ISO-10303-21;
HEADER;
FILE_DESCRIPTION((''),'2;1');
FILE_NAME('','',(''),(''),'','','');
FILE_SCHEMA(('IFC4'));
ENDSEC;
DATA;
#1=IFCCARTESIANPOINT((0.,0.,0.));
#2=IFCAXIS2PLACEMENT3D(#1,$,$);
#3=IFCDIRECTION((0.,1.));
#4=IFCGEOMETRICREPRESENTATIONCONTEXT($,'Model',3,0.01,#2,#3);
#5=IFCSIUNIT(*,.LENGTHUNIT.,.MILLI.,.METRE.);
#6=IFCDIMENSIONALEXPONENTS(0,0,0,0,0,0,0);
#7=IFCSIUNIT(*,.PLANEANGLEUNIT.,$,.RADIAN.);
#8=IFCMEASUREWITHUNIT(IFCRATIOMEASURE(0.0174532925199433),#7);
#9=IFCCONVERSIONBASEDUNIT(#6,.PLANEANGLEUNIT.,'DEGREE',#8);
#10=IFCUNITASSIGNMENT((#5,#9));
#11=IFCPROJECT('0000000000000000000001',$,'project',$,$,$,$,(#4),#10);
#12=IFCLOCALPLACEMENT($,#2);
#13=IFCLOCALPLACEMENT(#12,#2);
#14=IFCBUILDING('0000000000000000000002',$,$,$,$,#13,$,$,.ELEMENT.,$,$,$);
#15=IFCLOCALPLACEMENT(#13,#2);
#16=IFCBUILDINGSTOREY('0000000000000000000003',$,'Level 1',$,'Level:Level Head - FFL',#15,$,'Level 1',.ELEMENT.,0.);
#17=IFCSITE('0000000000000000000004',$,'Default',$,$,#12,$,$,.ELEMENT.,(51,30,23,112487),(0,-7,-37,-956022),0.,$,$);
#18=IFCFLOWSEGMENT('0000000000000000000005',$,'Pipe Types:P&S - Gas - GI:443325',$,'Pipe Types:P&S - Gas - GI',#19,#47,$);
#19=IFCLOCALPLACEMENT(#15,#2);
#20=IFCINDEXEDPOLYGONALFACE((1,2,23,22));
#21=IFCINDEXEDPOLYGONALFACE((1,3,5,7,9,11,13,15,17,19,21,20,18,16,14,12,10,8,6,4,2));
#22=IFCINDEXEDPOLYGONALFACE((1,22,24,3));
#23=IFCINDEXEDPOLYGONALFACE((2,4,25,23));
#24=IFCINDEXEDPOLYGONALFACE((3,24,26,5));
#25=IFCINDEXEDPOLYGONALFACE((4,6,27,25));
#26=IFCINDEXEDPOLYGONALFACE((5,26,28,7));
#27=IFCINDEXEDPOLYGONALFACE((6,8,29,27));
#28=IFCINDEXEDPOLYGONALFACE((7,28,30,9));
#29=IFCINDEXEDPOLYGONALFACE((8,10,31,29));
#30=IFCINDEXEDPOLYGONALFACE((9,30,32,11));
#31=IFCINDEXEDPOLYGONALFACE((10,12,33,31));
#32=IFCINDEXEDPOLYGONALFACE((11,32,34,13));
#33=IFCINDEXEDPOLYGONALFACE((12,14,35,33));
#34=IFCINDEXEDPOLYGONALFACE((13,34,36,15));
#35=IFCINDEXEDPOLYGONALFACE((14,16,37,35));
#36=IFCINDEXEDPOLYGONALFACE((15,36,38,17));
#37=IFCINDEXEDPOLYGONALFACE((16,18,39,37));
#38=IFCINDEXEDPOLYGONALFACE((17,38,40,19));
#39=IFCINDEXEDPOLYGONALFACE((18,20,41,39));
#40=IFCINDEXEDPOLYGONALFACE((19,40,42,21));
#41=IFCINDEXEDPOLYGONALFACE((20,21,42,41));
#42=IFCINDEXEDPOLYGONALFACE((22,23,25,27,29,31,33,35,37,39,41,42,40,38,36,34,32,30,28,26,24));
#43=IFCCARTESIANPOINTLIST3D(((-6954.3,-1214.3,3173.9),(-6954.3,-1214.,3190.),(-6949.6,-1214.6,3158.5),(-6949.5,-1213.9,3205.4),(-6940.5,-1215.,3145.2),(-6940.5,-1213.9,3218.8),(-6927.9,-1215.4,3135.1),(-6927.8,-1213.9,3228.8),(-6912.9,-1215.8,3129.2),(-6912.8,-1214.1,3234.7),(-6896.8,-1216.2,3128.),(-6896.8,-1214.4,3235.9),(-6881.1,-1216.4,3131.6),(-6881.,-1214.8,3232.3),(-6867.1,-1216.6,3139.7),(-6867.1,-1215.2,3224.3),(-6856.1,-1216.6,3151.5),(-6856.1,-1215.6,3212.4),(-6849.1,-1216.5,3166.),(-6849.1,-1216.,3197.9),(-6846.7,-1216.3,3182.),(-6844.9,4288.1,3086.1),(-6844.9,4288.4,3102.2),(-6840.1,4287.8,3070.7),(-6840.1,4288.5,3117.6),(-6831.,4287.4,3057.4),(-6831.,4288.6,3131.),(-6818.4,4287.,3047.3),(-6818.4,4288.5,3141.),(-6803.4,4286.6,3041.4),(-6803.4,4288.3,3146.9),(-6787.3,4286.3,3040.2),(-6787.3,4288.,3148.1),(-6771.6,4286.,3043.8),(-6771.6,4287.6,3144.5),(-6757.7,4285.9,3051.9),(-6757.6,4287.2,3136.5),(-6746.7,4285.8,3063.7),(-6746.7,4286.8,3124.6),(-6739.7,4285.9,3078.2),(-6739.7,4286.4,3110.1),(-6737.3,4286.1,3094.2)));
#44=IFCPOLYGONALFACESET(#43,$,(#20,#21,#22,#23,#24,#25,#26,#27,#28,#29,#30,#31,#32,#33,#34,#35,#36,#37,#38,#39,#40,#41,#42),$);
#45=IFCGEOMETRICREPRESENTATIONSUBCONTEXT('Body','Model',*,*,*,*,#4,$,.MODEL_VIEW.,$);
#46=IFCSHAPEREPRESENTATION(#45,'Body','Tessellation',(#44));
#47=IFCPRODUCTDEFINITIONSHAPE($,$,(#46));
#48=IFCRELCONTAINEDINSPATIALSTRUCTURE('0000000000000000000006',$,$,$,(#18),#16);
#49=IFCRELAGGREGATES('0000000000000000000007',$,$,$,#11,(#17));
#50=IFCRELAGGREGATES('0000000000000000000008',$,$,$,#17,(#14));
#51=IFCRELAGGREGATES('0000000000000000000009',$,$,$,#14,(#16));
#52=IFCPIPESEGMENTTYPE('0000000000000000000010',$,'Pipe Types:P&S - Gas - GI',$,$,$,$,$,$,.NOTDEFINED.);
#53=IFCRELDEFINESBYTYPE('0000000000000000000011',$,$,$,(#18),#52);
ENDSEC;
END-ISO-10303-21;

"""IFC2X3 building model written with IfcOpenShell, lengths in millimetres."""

from ifc_helpers import new_model, entity, si_unit, converted_unit, direction, frame, frame_2d, origin, place, context, subcontext, project, spatial, circle, extrude, type_object, element, save


model = new_model("IFC2X3")

# Units and contexts
model_context = context("Model", 3, precision=0.01, world=origin(), true_north=direction((0.0, 1.0)))
body_context = subcontext(model_context, "Body", "Model", "MODEL_VIEW")
ifc_project = project(units=[si_unit("LENGTHUNIT", "METRE", prefix="MILLI"), converted_unit("PLANEANGLEUNIT", "DEGREE", entity("IfcRatioMeasure", 0.0174532925199433), si_unit("PLANEANGLEUNIT", "RADIAN"), dimensions=[0, 0, 0, 0, 0, 0, 0])], contexts=[model_context])

# Site, building, storey
site_placement = place(None, origin())
site = spatial("IfcSite", under=ifc_project, at=site_placement, Name="Default", CompositionType="ELEMENT", RefLatitude=(51, 30, 23, 112487), RefLongitude=(0, -7, -37, -956022), RefElevation=0.0)
building_placement = place(site_placement, origin())
building = spatial("IfcBuilding", under=site, at=building_placement, CompositionType="ELEMENT")
storey_placement = place(building_placement, origin())
storey = spatial("IfcBuildingStorey", under=building, at=storey_placement, Name="Level 1", ObjectType="Level:Level Head - FFL", LongName="Level 1", CompositionType="ELEMENT", Elevation=0.0)

# Flow segment
pipe_segment_type = type_object("IfcPipeSegmentType", Name="Pipe Types:P&S - Gas - GI", PredefinedType="NOTDEFINED")
flow_segment_1_placement = place(storey_placement, origin())
element("IfcFlowSegment", 1, at=flow_segment_1_placement, inside=storey, type_object=pipe_segment_type, Name="Pipe Types:P&S - Gas - GI:443325", ObjectType="Pipe Types:P&S - Gas - GI", context=body_context, shape_type="SweptSolid", body=[
    extrude(circle(Radius=54.1, at=frame_2d((0.0, 0.0), x_axis=(1.0, 0.0))), frame((-6900.8, -1215.2, 3182.0), z_axis=(0.019883, 0.999675, -0.015953), x_axis=(0.999802, -0.019885, 0.0)), (0.0, 0.0, 1.0), 5504.2),
])

save(model, "model.ifc")
